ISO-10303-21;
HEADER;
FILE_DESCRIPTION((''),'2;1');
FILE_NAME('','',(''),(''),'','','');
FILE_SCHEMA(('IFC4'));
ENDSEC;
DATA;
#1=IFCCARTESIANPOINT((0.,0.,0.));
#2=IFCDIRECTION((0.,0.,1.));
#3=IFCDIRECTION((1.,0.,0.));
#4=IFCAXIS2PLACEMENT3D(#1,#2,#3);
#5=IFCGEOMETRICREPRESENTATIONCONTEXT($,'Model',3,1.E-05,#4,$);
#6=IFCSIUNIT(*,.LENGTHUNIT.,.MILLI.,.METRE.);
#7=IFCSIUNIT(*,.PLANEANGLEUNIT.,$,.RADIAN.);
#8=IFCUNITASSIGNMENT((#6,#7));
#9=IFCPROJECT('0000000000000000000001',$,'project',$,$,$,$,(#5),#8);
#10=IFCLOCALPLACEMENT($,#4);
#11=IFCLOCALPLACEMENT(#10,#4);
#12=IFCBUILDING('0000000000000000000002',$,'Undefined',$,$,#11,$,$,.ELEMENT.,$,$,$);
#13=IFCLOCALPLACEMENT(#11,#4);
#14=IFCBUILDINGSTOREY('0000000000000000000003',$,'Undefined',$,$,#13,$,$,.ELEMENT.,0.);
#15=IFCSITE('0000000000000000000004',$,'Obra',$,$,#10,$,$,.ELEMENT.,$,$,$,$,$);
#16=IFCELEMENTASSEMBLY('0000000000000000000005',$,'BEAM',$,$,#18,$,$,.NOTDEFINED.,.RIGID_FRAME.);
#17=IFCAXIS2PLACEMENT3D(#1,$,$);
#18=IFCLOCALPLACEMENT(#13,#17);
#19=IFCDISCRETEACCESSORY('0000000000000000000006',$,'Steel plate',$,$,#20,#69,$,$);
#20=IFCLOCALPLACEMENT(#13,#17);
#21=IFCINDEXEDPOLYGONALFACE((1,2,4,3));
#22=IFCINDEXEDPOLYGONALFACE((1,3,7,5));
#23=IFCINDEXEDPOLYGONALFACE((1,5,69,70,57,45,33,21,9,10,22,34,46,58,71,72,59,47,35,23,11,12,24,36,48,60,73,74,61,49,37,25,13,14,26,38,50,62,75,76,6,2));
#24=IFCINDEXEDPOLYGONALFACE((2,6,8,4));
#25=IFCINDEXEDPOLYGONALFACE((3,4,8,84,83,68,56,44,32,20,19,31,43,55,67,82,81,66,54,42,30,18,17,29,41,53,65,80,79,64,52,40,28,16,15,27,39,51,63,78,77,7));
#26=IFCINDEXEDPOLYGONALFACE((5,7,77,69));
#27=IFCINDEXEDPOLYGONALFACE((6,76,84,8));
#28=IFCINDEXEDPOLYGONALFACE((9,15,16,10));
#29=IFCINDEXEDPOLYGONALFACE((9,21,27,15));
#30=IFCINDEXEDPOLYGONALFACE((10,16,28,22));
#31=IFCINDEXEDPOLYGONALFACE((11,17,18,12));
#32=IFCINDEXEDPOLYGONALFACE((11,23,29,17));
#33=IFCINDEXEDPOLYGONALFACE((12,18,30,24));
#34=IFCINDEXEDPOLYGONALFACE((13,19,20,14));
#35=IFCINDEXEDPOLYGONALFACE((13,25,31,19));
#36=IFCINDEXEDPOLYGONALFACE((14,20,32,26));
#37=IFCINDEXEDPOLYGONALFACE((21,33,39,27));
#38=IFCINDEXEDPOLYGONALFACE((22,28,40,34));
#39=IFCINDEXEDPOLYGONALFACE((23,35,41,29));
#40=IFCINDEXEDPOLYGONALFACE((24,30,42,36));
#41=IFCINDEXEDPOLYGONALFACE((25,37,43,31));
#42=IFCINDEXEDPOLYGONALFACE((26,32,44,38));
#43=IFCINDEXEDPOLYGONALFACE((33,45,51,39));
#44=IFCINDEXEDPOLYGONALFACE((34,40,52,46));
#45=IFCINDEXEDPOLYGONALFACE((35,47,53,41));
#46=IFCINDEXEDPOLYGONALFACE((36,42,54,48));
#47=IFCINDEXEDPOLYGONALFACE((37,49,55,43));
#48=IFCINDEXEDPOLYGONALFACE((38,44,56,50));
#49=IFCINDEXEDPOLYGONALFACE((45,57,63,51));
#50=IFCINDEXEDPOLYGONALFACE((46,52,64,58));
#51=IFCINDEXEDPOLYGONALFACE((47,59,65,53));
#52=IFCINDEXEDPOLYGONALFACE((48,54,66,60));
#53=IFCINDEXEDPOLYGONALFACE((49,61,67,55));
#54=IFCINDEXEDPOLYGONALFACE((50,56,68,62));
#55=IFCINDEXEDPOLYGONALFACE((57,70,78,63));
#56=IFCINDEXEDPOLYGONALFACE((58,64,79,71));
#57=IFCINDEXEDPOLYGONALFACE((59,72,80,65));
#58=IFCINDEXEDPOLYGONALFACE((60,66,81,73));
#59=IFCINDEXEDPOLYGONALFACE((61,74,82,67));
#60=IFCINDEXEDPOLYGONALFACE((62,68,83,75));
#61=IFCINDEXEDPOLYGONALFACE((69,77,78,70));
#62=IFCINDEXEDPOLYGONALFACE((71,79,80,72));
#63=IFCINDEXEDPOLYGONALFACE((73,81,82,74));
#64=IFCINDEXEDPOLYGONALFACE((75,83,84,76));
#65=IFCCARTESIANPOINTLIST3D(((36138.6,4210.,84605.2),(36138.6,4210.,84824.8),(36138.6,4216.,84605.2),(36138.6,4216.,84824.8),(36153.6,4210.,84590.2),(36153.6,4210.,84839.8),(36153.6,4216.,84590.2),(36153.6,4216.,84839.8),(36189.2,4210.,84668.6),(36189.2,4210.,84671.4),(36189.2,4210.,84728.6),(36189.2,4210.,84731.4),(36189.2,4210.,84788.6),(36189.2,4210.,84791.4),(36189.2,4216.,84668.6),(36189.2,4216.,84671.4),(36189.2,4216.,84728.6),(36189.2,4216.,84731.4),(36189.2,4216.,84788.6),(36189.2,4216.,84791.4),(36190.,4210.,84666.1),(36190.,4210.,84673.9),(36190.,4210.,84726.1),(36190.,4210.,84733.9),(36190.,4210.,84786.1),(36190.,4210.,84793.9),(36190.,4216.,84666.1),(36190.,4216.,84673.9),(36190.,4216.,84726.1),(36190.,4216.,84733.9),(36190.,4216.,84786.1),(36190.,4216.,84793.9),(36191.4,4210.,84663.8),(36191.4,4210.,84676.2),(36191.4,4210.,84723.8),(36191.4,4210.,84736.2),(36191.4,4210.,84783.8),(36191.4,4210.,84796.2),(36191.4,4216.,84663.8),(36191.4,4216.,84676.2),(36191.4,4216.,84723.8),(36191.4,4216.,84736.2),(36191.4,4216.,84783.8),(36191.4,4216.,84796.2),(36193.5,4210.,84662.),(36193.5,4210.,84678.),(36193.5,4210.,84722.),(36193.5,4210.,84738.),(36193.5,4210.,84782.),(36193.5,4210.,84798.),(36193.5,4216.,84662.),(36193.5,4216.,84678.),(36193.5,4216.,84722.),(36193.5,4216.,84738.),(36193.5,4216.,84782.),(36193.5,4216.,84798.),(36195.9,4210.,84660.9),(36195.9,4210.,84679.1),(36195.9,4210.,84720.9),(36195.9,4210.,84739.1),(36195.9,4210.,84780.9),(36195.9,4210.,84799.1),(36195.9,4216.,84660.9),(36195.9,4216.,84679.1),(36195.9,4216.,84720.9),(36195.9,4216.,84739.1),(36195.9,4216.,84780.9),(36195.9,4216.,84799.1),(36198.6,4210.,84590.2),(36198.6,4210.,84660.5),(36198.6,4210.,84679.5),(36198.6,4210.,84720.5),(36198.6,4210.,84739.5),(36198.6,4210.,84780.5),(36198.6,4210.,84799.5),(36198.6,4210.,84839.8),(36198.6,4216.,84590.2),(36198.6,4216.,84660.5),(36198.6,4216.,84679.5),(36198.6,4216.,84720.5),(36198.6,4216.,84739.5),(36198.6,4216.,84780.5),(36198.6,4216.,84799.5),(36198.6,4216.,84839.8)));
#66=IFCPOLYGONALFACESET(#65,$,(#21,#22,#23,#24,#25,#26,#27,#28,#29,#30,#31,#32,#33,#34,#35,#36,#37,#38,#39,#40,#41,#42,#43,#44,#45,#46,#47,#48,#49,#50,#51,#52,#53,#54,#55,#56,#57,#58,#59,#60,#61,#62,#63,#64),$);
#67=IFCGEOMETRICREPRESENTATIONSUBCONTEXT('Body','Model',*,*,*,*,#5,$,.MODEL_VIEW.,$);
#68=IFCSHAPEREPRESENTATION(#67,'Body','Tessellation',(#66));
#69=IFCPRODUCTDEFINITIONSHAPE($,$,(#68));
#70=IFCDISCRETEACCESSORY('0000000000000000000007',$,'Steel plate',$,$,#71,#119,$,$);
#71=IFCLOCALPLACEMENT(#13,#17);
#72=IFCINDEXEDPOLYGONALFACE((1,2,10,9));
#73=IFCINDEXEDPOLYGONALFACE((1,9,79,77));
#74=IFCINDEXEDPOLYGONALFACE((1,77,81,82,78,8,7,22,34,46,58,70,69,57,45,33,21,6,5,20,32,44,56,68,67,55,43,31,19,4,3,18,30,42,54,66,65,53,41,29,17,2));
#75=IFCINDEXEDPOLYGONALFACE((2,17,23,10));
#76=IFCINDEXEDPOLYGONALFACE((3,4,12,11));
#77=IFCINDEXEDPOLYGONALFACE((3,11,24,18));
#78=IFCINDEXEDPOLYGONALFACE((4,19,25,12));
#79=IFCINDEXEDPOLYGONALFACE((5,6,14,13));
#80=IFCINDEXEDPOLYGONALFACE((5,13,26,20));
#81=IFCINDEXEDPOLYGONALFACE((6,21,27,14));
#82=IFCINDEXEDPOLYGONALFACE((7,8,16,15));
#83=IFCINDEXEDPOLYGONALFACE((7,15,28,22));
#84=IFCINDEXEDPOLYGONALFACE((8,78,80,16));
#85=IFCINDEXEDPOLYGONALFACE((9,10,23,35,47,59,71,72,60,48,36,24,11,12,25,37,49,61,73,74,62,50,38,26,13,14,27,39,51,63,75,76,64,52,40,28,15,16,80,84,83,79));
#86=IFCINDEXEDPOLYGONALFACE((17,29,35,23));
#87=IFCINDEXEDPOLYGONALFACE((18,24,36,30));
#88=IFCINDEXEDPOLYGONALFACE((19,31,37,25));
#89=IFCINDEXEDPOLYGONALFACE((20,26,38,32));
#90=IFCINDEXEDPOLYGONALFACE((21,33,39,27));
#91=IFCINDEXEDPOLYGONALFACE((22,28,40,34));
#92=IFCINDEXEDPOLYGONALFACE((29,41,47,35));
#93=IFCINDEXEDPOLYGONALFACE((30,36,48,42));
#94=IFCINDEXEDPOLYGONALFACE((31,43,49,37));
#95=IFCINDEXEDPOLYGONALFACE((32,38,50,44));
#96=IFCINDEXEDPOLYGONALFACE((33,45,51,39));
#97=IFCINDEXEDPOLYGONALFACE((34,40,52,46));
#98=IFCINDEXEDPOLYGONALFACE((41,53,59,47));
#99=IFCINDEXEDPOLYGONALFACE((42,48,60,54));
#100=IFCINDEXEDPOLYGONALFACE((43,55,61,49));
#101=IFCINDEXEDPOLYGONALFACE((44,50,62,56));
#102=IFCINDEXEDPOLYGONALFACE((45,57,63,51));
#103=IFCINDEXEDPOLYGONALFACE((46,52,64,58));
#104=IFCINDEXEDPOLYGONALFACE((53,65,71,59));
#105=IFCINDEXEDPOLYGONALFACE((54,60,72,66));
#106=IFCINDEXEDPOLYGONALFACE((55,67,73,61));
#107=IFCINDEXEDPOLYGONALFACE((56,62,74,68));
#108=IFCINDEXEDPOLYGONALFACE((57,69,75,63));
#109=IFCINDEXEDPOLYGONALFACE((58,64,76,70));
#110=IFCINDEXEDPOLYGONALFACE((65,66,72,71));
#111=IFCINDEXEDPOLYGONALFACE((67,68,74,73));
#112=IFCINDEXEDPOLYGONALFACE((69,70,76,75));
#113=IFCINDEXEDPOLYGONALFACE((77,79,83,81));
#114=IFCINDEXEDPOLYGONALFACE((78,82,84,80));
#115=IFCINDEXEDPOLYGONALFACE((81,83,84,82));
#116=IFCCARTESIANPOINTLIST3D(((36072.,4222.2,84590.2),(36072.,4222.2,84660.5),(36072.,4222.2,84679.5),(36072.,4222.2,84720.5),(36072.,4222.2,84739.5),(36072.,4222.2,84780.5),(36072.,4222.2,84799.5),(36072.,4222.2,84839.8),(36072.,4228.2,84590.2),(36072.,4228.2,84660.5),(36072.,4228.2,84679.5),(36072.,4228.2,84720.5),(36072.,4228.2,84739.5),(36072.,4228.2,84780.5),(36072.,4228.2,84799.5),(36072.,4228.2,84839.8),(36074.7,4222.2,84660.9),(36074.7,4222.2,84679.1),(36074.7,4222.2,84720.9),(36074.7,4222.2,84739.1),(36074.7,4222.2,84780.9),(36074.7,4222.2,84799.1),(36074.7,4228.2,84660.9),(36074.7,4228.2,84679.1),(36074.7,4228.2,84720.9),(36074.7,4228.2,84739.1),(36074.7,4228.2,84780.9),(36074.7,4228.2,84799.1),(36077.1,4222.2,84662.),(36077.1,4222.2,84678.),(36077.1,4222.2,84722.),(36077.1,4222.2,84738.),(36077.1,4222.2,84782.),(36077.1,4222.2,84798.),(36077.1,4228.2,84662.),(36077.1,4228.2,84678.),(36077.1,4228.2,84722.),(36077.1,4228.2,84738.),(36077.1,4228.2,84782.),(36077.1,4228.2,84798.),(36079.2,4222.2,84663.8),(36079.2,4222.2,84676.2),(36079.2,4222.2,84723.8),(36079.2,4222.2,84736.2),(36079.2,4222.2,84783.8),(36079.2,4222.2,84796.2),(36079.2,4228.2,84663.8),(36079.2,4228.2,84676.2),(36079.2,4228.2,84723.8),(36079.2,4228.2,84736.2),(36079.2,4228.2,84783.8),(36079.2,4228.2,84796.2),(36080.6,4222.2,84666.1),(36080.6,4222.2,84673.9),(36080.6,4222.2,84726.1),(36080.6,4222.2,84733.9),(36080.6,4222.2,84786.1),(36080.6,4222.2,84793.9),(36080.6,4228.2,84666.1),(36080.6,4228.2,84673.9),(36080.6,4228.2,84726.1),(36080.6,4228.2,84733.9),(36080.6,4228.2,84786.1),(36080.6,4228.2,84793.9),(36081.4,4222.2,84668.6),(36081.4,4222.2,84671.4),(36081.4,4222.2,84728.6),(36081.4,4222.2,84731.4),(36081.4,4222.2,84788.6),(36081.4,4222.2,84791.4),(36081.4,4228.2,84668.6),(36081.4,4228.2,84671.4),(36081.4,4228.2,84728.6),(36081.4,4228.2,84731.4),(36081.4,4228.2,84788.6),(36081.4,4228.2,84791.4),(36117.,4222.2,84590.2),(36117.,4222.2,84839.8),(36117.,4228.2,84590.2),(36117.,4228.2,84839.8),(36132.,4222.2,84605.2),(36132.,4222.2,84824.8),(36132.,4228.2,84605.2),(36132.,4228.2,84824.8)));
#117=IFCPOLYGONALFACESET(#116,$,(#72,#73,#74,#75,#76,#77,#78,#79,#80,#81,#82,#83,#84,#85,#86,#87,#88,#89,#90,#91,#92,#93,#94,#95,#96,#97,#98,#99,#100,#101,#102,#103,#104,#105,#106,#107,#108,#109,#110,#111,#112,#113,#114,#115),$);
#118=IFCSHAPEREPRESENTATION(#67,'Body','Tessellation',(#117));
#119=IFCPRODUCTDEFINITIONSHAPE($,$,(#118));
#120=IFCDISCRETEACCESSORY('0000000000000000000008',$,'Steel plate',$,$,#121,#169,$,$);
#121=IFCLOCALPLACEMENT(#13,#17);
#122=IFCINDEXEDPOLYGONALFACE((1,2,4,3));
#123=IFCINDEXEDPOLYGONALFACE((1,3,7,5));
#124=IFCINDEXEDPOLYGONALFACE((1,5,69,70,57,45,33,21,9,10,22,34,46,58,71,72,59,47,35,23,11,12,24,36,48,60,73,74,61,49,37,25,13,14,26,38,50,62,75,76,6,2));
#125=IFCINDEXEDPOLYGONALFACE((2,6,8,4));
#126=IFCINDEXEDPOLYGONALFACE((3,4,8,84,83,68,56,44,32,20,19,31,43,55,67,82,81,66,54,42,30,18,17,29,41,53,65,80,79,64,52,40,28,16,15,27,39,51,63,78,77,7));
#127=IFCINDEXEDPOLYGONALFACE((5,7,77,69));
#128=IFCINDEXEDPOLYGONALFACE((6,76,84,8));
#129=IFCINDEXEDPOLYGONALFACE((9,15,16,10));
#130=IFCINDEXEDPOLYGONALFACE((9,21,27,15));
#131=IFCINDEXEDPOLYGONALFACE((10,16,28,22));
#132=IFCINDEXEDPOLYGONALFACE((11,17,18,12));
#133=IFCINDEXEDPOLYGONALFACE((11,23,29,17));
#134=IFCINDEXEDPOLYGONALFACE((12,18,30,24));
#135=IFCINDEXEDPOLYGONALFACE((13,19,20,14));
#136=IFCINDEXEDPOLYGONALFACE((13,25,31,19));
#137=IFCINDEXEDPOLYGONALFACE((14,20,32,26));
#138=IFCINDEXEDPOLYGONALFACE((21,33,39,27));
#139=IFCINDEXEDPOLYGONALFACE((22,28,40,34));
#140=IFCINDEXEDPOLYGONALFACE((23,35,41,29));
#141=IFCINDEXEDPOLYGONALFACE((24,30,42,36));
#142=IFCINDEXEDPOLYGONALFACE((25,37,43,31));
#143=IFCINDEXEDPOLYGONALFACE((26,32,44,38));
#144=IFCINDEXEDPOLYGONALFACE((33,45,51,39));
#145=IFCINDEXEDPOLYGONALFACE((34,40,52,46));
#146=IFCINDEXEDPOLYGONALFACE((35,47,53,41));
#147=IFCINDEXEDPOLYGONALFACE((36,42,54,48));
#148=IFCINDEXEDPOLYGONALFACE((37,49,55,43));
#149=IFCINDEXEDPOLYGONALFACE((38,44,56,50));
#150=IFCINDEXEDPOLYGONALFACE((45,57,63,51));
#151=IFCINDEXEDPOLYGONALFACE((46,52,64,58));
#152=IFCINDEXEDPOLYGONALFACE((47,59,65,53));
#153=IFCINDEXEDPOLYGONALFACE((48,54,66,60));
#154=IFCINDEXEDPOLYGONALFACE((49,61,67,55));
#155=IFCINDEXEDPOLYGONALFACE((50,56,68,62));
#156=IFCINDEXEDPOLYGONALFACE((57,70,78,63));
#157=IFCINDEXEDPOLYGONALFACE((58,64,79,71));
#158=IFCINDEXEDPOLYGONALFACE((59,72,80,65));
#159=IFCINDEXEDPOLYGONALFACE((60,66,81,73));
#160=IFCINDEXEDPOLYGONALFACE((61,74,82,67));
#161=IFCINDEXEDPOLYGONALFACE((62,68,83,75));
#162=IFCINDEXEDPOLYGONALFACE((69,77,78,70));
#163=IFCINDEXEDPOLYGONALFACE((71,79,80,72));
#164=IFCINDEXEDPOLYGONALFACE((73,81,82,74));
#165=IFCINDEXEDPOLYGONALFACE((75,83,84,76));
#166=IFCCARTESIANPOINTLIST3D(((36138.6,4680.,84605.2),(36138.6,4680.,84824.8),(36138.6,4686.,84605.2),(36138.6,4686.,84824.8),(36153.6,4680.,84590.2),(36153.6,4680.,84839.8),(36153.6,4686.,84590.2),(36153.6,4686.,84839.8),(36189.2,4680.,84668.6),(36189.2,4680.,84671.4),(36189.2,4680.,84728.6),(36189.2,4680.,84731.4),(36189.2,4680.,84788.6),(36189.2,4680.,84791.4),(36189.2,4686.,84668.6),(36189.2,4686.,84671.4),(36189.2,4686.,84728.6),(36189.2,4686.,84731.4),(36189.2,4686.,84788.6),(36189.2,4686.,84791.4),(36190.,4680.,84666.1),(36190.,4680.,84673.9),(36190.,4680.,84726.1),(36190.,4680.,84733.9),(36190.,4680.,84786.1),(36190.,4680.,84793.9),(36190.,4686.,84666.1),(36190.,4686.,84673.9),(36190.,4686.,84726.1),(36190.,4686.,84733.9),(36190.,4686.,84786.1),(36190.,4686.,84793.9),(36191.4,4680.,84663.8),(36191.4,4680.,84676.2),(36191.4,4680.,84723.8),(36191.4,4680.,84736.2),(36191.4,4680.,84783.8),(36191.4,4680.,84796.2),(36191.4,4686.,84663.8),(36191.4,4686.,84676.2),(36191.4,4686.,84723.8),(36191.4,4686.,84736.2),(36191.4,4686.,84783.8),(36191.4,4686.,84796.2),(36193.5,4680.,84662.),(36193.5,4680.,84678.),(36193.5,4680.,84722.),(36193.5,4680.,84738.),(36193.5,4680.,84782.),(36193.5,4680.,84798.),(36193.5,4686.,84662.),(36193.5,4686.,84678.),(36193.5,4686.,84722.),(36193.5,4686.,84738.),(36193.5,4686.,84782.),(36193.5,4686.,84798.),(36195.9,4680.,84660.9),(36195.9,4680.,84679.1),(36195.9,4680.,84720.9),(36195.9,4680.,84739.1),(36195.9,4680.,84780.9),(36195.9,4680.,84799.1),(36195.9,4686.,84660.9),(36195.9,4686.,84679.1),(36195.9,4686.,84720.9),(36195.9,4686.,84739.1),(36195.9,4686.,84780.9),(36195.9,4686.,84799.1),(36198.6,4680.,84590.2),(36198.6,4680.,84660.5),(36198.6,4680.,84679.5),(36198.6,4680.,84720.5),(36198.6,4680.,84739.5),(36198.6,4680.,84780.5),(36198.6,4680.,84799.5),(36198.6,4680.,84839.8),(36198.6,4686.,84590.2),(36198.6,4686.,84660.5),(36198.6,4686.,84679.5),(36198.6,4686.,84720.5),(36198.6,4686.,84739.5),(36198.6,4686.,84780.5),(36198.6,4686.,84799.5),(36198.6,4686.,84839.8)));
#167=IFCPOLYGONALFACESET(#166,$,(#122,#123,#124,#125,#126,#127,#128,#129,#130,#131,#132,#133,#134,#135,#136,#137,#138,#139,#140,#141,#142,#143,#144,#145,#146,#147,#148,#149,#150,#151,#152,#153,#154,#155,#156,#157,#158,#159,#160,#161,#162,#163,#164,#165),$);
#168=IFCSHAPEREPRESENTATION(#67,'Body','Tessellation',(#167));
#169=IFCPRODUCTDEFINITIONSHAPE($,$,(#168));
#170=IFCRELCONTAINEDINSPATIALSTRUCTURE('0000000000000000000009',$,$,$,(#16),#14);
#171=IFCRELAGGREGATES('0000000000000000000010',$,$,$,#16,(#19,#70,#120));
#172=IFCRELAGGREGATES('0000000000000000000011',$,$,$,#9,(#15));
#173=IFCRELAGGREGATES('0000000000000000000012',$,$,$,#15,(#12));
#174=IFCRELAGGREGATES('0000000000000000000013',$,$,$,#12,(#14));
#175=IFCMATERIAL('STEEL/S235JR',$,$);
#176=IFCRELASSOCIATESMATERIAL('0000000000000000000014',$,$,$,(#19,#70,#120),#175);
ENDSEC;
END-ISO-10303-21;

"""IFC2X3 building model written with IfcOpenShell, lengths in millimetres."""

from ifc_helpers import new_model, si_unit, frame, origin_with_axes, origin_2d_with_axis, place, context, subcontext, project, spatial, polyline, circle, outline, extrude, source, transform, mapped, material, element, aggregate, save


model = new_model("IFC2X3")

# Units and contexts
model_context = context("Model", 3, precision=1e-05, world=origin_with_axes())
body_context = subcontext(model_context, "Body", "Model", "MODEL_VIEW")
ifc_project = project(units=[si_unit("LENGTHUNIT", "METRE", prefix="MILLI"), si_unit("PLANEANGLEUNIT", "RADIAN")], contexts=[model_context])

# Site, building, storey
site_placement = place(None, origin_with_axes())
site = spatial("IfcSite", under=ifc_project, at=site_placement, Name="Obra", CompositionType="ELEMENT")
building_placement = place(site_placement, origin_with_axes())
building = spatial("IfcBuilding", under=site, at=building_placement, Name="Undefined", CompositionType="ELEMENT")
storey_placement = place(building_placement, origin_with_axes())
storey = spatial("IfcBuildingStorey", under=building, at=storey_placement, Name="Undefined", CompositionType="ELEMENT", Elevation=0.0)

# Element assembly
ifc_material_1 = material(Name="STEEL/S235JR")
assembly_1_placement = place(storey_placement, origin_with_axes())
assembly_1 = element("IfcElementAssembly", 1, at=assembly_1_placement, inside=storey, Name="BEAM", AssemblyPlace="NOTDEFINED", PredefinedType="RIGID_FRAME")

# Discrete accessories, openings
discrete_accessory_1_placement = place(assembly_1_placement, frame((36198.6, 4213.0, 84590.2), z_axis=(0.0, 1.0, 0.0), x_axis=(-1.0, 0.0, 0.0)))
discrete_accessory_1 = element("IfcDiscreteAccessory", 2, at=discrete_accessory_1_placement, material=ifc_material_1, Name="Steel plate", context=body_context, shape_type="SweptSolid", body=[
    extrude(outline(polyline([(0.0, 0.0), (45.0, 0.0), (60.0, 15.0), (60.0, 234.6), (45.0, 249.6), (0.0, 249.6), (0.0, 0.0)])), frame((0.0, 0.0, -3.0), z_axis=(0.0, 0.0, 1.0), x_axis=(1.0, 0.0, 0.0)), (0.0, 0.0, 1.0), 6.0),
])
shared_shape_1 = source(origin_with_axes(), body_context, "Body", "SweptSolid", [
    extrude(circle(Radius=9.5, at=origin_2d_with_axis()), frame((0.0, -9.2, 0.0), z_axis=(0.0, 1.0, 0.0), x_axis=(1.0, 0.0, 0.0)), (0.0, 0.0, 1.0), 6.2),
])
opening_1_placement = place(assembly_1_placement, frame((36148.6, 4219.1, 84850.0), z_axis=(1.0, 0.0, 0.0), x_axis=(0.0, 0.0, -1.0)))
element("IfcOpeningElement", 3, at=opening_1_placement, cuts=discrete_accessory_1, ObjectType="Opening", context=body_context, shape_type="MappedRepresentation", body=[
    mapped(shared_shape_1, transform((60.0, 0.0, 50.0))),
    mapped(shared_shape_1, transform((120.0, 0.0, 50.0))),
    mapped(shared_shape_1, transform((180.0, 0.0, 50.0))),
])
discrete_accessory_2_placement = place(assembly_1_placement, frame((36072.0, 4225.2, 84590.2), z_axis=(0.0, -1.0, 0.0), x_axis=(1.0, 0.0, 0.0)))
discrete_accessory_2 = element("IfcDiscreteAccessory", 4, at=discrete_accessory_2_placement, material=ifc_material_1, Name="Steel plate", context=body_context, shape_type="SweptSolid", body=[
    extrude(outline(polyline([(0.0, 0.0), (45.0, 0.0), (60.0, 15.0), (60.0, 234.6), (45.0, 249.6), (0.0, 249.6), (0.0, 0.0)])), frame((0.0, 0.0, -3.0), z_axis=(0.0, 0.0, 1.0), x_axis=(1.0, 0.0, 0.0)), (0.0, 0.0, 1.0), 6.0),
])
opening_2_placement = place(assembly_1_placement, frame((36122.0, 4219.1, 84850.0), z_axis=(-1.0, 0.0, 0.0), x_axis=(0.0, 0.0, -1.0)))
element("IfcOpeningElement", 5, at=opening_2_placement, cuts=discrete_accessory_2, ObjectType="Opening", context=body_context, shape_type="MappedRepresentation", body=[
    mapped(shared_shape_1, transform((60.0, 0.0, 50.0))),
    mapped(shared_shape_1, transform((120.0, 0.0, 50.0))),
    mapped(shared_shape_1, transform((180.0, 0.0, 50.0))),
])
discrete_accessory_3_placement = place(assembly_1_placement, frame((36198.6, 4683.0, 84590.2), z_axis=(0.0, 1.0, 0.0), x_axis=(-1.0, 0.0, 0.0)))
discrete_accessory_3 = element("IfcDiscreteAccessory", 6, at=discrete_accessory_3_placement, material=ifc_material_1, Name="Steel plate", context=body_context, shape_type="SweptSolid", body=[
    extrude(outline(polyline([(0.0, 0.0), (45.0, 0.0), (60.0, 15.0), (60.0, 234.6), (45.0, 249.6), (0.0, 249.6), (0.0, 0.0)])), frame((0.0, 0.0, -3.0), z_axis=(0.0, 0.0, 1.0), x_axis=(1.0, 0.0, 0.0)), (0.0, 0.0, 1.0), 6.0),
])
opening_3_placement = place(assembly_1_placement, frame((36148.6, 4689.1, 84850.0), z_axis=(1.0, 0.0, 0.0), x_axis=(0.0, 0.0, -1.0)))
element("IfcOpeningElement", 7, at=opening_3_placement, cuts=discrete_accessory_3, ObjectType="Opening", context=body_context, shape_type="MappedRepresentation", body=[
    mapped(shared_shape_1, transform((60.0, 0.0, 50.0))),
    mapped(shared_shape_1, transform((120.0, 0.0, 50.0))),
    mapped(shared_shape_1, transform((180.0, 0.0, 50.0))),
])
aggregate(assembly_1, [discrete_accessory_1, discrete_accessory_2, discrete_accessory_3])

save(model, "model.ifc")
